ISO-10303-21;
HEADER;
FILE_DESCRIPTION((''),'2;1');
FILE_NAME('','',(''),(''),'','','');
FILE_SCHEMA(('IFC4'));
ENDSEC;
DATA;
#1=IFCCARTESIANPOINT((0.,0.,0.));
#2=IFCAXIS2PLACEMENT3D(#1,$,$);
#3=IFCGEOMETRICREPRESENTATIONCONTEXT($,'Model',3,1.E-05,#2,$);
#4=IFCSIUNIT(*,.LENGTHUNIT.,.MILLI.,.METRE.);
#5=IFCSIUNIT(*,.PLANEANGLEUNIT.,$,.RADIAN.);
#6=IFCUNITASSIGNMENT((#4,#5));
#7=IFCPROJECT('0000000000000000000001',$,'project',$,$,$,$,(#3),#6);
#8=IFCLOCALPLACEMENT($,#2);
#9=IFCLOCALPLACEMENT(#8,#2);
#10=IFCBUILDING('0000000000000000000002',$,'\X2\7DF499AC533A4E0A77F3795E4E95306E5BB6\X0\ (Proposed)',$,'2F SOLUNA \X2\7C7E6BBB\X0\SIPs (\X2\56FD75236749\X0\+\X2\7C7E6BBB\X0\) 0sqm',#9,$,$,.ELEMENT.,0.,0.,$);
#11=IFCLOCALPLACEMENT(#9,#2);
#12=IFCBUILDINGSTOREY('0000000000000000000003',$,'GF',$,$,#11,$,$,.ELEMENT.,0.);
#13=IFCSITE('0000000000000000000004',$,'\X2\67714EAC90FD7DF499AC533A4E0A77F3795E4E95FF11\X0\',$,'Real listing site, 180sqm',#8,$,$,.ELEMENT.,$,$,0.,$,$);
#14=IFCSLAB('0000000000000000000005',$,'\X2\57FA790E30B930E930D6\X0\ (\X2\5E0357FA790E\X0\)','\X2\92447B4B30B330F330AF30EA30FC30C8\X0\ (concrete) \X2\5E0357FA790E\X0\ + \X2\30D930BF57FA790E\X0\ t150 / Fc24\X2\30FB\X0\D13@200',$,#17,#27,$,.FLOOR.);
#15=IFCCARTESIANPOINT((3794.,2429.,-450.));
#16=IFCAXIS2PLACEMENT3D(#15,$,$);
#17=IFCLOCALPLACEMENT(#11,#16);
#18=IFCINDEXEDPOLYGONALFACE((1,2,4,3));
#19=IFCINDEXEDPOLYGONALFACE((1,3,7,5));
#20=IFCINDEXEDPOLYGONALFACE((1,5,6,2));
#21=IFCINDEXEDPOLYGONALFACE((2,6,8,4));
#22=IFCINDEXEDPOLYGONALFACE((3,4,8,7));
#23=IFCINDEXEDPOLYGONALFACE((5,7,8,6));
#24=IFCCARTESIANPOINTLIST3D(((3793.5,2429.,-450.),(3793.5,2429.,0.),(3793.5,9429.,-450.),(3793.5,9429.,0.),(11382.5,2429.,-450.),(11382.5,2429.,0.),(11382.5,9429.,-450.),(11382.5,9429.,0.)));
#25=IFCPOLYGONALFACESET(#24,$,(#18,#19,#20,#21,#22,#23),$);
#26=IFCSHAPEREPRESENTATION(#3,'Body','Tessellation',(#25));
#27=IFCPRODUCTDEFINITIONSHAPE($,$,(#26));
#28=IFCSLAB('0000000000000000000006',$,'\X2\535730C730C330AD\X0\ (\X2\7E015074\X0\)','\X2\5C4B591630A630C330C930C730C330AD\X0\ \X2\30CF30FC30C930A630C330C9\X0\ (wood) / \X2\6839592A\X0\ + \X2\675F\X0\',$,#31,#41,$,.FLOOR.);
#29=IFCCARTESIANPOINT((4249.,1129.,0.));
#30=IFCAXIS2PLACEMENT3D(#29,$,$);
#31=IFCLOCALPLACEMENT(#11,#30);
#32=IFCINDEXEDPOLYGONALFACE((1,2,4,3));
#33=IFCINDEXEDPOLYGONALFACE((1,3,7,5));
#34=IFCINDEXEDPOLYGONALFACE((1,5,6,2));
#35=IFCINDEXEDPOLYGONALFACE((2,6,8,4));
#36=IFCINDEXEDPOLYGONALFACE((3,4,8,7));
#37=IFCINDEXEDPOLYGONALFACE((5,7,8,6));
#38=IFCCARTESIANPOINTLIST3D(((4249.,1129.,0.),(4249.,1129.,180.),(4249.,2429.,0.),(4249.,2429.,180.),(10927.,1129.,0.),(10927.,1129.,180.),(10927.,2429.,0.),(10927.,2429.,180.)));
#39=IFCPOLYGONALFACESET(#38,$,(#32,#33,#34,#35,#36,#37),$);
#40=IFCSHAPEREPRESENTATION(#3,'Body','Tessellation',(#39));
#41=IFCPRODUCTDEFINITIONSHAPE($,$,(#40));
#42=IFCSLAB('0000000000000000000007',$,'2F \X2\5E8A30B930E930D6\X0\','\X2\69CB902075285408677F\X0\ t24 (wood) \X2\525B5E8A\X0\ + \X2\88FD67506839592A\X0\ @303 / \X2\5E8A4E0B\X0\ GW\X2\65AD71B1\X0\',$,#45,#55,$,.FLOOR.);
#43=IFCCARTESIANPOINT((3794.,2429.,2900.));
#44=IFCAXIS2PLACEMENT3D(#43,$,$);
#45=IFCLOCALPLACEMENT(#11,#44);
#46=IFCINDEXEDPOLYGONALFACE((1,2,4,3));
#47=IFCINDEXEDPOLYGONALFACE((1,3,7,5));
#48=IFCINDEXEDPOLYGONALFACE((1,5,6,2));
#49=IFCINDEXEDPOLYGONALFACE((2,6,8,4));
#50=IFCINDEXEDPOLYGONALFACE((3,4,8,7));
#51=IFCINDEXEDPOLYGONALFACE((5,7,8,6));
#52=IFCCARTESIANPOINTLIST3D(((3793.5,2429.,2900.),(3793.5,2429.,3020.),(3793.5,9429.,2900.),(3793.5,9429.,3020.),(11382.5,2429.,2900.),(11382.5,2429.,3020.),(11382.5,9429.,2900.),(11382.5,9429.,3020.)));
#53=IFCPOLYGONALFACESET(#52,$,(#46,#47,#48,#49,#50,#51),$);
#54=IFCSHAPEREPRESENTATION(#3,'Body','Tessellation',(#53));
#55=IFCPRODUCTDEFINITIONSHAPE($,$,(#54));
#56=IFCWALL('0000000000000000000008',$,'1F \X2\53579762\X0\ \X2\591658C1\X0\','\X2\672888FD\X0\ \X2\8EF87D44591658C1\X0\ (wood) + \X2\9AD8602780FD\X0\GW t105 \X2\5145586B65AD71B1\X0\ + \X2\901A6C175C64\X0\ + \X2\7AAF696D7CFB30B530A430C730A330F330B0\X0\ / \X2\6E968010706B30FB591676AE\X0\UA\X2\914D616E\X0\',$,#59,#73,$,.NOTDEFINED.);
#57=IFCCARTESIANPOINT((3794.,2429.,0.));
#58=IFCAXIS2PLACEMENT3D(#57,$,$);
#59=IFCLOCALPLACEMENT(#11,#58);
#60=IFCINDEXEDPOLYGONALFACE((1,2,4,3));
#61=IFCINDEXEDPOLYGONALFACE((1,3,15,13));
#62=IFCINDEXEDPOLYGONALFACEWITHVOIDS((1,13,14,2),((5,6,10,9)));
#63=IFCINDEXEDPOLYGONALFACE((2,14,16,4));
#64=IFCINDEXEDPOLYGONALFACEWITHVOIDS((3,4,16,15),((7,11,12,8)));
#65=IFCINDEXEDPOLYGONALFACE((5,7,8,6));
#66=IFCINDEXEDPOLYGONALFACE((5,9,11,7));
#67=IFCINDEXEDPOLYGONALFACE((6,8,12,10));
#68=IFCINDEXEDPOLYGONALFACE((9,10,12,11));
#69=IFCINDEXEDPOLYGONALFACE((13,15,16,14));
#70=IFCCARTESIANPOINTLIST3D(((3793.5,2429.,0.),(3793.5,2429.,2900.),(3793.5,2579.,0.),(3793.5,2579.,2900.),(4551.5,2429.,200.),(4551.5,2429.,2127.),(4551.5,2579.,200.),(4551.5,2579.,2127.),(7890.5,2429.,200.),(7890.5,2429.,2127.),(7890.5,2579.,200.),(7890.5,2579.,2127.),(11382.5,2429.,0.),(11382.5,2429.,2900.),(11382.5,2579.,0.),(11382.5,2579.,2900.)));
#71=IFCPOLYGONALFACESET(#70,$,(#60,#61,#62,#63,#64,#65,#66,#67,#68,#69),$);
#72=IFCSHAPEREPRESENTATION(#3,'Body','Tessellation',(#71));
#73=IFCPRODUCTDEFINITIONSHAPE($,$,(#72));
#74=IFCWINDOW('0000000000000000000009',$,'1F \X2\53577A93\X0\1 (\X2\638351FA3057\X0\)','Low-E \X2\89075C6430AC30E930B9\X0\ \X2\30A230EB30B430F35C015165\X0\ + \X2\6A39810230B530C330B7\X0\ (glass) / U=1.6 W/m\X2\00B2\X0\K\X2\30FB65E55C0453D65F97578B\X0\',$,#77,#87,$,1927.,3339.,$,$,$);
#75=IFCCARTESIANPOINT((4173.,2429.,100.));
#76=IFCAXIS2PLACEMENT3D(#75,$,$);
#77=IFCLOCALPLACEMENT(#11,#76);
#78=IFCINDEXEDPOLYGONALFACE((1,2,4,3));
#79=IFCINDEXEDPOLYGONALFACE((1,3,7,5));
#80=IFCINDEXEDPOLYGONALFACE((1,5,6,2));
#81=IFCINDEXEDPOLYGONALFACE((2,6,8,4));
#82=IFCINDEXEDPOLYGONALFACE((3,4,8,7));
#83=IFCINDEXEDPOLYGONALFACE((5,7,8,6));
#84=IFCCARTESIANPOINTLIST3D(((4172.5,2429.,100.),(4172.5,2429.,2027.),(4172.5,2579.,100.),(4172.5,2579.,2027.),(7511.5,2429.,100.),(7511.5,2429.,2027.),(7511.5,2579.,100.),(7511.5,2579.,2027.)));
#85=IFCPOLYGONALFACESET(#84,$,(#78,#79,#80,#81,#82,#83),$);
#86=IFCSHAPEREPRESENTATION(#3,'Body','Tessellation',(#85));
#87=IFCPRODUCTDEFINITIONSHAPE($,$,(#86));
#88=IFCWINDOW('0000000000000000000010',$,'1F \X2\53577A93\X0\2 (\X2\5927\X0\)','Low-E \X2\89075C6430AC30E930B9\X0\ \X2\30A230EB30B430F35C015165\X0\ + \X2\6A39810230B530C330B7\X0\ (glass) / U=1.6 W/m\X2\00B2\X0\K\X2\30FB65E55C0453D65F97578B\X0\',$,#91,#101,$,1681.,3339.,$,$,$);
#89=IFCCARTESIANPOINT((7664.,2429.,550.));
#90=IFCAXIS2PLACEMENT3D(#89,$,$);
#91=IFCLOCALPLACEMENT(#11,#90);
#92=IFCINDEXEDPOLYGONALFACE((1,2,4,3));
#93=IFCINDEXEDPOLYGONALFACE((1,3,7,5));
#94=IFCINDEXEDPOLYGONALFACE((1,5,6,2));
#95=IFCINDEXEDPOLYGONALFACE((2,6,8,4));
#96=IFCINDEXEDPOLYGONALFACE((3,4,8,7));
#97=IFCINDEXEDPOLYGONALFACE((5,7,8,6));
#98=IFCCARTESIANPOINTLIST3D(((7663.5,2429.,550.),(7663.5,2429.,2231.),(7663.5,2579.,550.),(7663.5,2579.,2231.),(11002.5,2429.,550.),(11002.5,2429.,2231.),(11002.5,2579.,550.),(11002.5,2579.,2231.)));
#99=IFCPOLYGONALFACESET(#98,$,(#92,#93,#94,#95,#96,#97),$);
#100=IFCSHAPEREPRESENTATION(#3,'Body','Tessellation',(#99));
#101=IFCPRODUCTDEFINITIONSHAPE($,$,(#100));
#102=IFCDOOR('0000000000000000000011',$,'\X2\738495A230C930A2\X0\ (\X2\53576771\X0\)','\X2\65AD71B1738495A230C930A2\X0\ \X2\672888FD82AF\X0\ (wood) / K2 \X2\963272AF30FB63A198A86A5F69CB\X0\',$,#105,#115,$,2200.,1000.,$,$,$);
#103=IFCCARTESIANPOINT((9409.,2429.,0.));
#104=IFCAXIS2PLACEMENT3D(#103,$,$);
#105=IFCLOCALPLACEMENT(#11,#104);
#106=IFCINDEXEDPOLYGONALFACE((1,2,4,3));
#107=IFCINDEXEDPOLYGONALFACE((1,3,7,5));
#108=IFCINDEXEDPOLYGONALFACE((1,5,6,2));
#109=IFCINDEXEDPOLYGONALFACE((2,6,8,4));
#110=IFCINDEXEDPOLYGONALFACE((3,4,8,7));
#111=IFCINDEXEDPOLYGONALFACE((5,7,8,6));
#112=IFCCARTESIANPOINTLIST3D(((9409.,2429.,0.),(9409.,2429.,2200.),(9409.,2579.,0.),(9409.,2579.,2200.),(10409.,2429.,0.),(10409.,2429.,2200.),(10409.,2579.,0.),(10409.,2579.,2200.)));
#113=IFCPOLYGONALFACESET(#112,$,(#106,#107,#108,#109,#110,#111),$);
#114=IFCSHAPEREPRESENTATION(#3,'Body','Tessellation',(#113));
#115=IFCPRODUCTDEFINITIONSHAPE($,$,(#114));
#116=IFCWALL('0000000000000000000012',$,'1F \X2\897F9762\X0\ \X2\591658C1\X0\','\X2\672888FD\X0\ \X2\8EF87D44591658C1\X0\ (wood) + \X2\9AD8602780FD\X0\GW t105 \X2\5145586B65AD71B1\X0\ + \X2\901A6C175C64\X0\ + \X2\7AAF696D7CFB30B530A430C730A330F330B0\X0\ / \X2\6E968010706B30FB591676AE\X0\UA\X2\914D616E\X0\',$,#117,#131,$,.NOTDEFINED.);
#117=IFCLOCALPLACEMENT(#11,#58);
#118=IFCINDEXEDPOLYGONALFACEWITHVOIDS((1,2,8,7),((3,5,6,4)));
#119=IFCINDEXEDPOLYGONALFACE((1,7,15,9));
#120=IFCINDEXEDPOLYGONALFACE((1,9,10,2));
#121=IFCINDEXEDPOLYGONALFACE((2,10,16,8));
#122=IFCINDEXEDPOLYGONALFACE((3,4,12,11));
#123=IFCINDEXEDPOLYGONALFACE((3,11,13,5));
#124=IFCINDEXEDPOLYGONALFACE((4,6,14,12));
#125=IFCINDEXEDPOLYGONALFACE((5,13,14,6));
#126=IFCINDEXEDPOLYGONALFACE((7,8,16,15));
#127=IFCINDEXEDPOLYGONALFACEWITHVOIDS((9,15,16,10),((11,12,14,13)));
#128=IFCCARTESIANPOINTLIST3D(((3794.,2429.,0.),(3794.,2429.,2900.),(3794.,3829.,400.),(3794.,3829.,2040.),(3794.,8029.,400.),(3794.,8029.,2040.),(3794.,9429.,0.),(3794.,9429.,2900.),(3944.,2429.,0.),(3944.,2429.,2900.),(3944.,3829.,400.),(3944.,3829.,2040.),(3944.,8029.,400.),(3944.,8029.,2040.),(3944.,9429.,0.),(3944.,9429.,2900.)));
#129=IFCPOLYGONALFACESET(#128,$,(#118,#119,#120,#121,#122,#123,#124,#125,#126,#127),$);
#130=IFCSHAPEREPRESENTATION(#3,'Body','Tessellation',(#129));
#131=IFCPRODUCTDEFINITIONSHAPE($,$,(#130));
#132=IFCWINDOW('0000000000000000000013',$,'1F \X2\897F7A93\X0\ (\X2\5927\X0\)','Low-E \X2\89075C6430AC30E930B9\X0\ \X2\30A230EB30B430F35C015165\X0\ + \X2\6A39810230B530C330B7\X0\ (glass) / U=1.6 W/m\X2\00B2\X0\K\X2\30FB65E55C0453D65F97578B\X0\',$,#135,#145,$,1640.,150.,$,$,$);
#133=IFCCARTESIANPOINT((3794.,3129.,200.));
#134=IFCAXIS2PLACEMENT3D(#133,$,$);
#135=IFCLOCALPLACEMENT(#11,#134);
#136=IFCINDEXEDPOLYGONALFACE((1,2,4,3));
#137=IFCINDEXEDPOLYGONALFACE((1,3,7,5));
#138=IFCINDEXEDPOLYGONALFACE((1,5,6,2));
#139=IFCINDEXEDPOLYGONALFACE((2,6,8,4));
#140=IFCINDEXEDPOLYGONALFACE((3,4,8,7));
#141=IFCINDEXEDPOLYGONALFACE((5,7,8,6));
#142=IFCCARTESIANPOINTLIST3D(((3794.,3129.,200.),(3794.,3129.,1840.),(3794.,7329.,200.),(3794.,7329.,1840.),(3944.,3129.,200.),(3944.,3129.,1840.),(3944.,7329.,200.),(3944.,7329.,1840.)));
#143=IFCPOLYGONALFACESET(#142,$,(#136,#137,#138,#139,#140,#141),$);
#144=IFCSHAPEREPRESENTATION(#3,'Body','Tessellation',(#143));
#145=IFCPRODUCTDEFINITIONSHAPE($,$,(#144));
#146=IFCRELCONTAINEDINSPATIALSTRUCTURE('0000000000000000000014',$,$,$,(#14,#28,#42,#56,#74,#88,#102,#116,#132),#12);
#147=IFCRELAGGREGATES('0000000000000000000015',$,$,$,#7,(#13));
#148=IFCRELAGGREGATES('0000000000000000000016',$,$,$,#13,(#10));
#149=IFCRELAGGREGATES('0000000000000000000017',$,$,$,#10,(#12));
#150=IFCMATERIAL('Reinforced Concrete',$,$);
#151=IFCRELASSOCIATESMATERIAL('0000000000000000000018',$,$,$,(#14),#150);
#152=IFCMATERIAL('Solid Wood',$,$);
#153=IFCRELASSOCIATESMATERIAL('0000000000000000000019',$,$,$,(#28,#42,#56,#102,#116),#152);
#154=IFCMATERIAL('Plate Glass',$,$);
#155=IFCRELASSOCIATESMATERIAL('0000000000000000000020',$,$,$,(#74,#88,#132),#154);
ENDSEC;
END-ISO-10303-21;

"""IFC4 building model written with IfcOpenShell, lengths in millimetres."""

from ifc_helpers import new_model, si_unit, frame, frame_2d, origin, place, context, project, spatial, rectangle, extrude, material, element, fill, save


model = new_model("IFC4")

# Units and contexts
model_context = context("Model", 3, precision=1e-05, world=origin())
ifc_project = project(units=[si_unit("LENGTHUNIT", "METRE", prefix="MILLI"), si_unit("PLANEANGLEUNIT", "RADIAN")], contexts=[model_context])

# Site, building, storey
site_placement = place(None, origin())
site = spatial("IfcSite", under=ifc_project, at=site_placement, Name="東京都練馬区上石神井１", ObjectType="Real listing site, 180sqm", CompositionType="ELEMENT", RefElevation=0.0)
building_placement = place(site_placement, origin())
building = spatial("IfcBuilding", under=site, at=building_placement, Name="練馬区上石神井の家 (Proposed)", ObjectType="2F SOLUNA 籾殻SIPs (国産杉+籾殻) 0sqm", CompositionType="ELEMENT", ElevationOfRefHeight=0.0, ElevationOfTerrain=0.0)
storey_placement = place(building_placement, origin())
storey = spatial("IfcBuildingStorey", under=building, at=storey_placement, Name="GF", CompositionType="ELEMENT", Elevation=0.0)

# Slabs
ifc_material_1 = material(Name="Reinforced Concrete")
slab_1_placement = place(storey_placement, frame((3794.0, 2429.0, -450.0)))
element("IfcSlab", 1, at=slab_1_placement, inside=storey, material=ifc_material_1, Name="基礎スラブ (布基礎)", Description="鉄筋コンクリート (concrete) 布基礎 + ベタ基礎 t150 / Fc24・D13@200", PredefinedType="FLOOR", context=model_context, shape_type="SweptSolid", body=[
    extrude(rectangle(XDim=7589.0, YDim=7000.0, at=frame_2d((3794.0, 3500.0))), frame((3794.0, 2429.0, -450.0)), (0.0, 0.0, 1.0), 450.0),
])
ifc_material_2 = material(Name="Solid Wood")
slab_2_placement = place(storey_placement, frame((4249.0, 1129.0, 0.0)))
element("IfcSlab", 2, at=slab_2_placement, inside=storey, material=ifc_material_2, Name="南デッキ (縁側)", Description="屋外ウッドデッキ ハードウッド (wood) / 根太 + 束", PredefinedType="FLOOR", context=model_context, shape_type="SweptSolid", body=[
    extrude(rectangle(XDim=6678.0, YDim=1300.0, at=frame_2d((3339.0, 650.0))), frame((4249.0, 1129.0, 0.0)), (0.0, 0.0, 1.0), 180.0),
])
slab_3_placement = place(storey_placement, frame((3794.0, 2429.0, 2900.0)))
element("IfcSlab", 3, at=slab_3_placement, inside=storey, material=ifc_material_2, Name="2F 床スラブ", Description="構造用合板 t24 (wood) 剛床 + 製材根太 @303 / 床下 GW断熱", PredefinedType="FLOOR", context=model_context, shape_type="SweptSolid", body=[
    extrude(rectangle(XDim=7589.0, YDim=7000.0, at=frame_2d((3794.0, 3500.0))), frame((3794.0, 2429.0, 2900.0)), (0.0, 0.0, 1.0), 120.0),
])

# Wall, openings, windows, door
wall_1_placement = place(storey_placement, frame((3794.0, 2429.0, 0.0)))
wall_1 = element("IfcWall", 4, at=wall_1_placement, inside=storey, material=ifc_material_2, Name="1F 南面 外壁", Description="木製 軸組外壁 (wood) + 高性能GW t105 充填断熱 + 通気層 + 窯業系サイディング / 準耐火・外皮UA配慮", PredefinedType="NOTDEFINED", context=model_context, shape_type="SweptSolid", body=[
    extrude(rectangle(XDim=7589.0, YDim=150.0, at=frame_2d((3794.0, 75.0))), frame((3794.0, 2429.0, 0.0)), (0.0, 0.0, 1.0), 2900.0),
])
opening_1_placement = place(storey_placement, frame((4173.0, 2429.0, 100.0)))
opening_1 = element("IfcOpeningElement", 5, at=opening_1_placement, cuts=wall_1, PredefinedType="NOTDEFINED", context=model_context, shape_type="SweptSolid", body=[
    extrude(rectangle(XDim=3339.0, YDim=150.0, at=frame_2d((1669.0, 75.0))), frame((4173.0, 2429.0, 100.0)), (0.0, 0.0, 1.0), 1927.0),
])
opening_2_placement = place(storey_placement, frame((7664.0, 2429.0, 550.0)))
opening_2 = element("IfcOpeningElement", 6, at=opening_2_placement, cuts=wall_1, PredefinedType="NOTDEFINED", context=model_context, shape_type="SweptSolid", body=[
    extrude(rectangle(XDim=3339.0, YDim=150.0, at=frame_2d((1669.0, 75.0))), frame((7664.0, 2429.0, 550.0)), (0.0, 0.0, 1.0), 1681.0),
])
opening_3_placement = place(storey_placement, frame((9409.0, 2429.0, 0.0)))
opening_3 = element("IfcOpeningElement", 7, at=opening_3_placement, cuts=wall_1, PredefinedType="NOTDEFINED", context=model_context, shape_type="SweptSolid", body=[
    extrude(rectangle(XDim=1000.0, YDim=150.0, at=frame_2d((500.0, 75.0))), frame((9409.0, 2429.0, 0.0)), (0.0, 0.0, 1.0), 2200.0),
])
ifc_material_3 = material(Name="Plate Glass")
window_1_placement = place(storey_placement, frame((4173.0, 2429.0, 100.0)))
window_1 = element("IfcWindow", 8, at=window_1_placement, inside=storey, material=ifc_material_3, Name="1F 南窓1 (掃出し)", Description="Low-E 複層ガラス アルゴン封入 + 樹脂サッシ (glass) / U=1.6 W/m²K・日射取得型", OverallHeight=1927.0, OverallWidth=3339.0, context=model_context, shape_type="SweptSolid", body=[
    extrude(rectangle(XDim=3339.0, YDim=150.0, at=frame_2d((1669.0, 75.0))), frame((4173.0, 2429.0, 100.0)), (0.0, 0.0, 1.0), 1927.0),
])
fill(opening_1, window_1)
window_2_placement = place(storey_placement, frame((7664.0, 2429.0, 550.0)))
window_2 = element("IfcWindow", 9, at=window_2_placement, inside=storey, material=ifc_material_3, Name="1F 南窓2 (大)", Description="Low-E 複層ガラス アルゴン封入 + 樹脂サッシ (glass) / U=1.6 W/m²K・日射取得型", OverallHeight=1681.0, OverallWidth=3339.0, context=model_context, shape_type="SweptSolid", body=[
    extrude(rectangle(XDim=3339.0, YDim=150.0, at=frame_2d((1669.0, 75.0))), frame((7664.0, 2429.0, 550.0)), (0.0, 0.0, 1.0), 1681.0),
])
fill(opening_2, window_2)
door_placement = place(storey_placement, frame((9409.0, 2429.0, 0.0)))
door = element("IfcDoor", 10, at=door_placement, inside=storey, material=ifc_material_2, Name="玄関ドア (南東)", Description="断熱玄関ドア 木製芯 (wood) / K2 防犯・採風機構", OverallHeight=2200.0, OverallWidth=1000.0, context=model_context, shape_type="SweptSolid", body=[
    extrude(rectangle(XDim=1000.0, YDim=150.0, at=frame_2d((500.0, 75.0))), frame((9409.0, 2429.0, 0.0)), (0.0, 0.0, 1.0), 2200.0),
])
fill(opening_3, door)

# Wall, opening, window
wall_2_placement = place(storey_placement, frame((3794.0, 2429.0, 0.0)))
wall_2 = element("IfcWall", 11, at=wall_2_placement, inside=storey, material=ifc_material_2, Name="1F 西面 外壁", Description="木製 軸組外壁 (wood) + 高性能GW t105 充填断熱 + 通気層 + 窯業系サイディング / 準耐火・外皮UA配慮", PredefinedType="NOTDEFINED", context=model_context, shape_type="SweptSolid", body=[
    extrude(rectangle(XDim=150.0, YDim=7000.0, at=frame_2d((75.0, 3500.0))), frame((3794.0, 2429.0, 0.0)), (0.0, 0.0, 1.0), 2900.0),
])
opening_4_placement = place(storey_placement, frame((3794.0, 3129.0, 200.0)))
opening_4 = element("IfcOpeningElement", 12, at=opening_4_placement, cuts=wall_2, PredefinedType="NOTDEFINED", context=model_context, shape_type="SweptSolid", body=[
    extrude(rectangle(XDim=150.0, YDim=4200.0, at=frame_2d((75.0, 2100.0))), frame((3794.0, 3129.0, 200.0)), (0.0, 0.0, 1.0), 1640.0),
])
window_3_placement = place(storey_placement, frame((3794.0, 3129.0, 200.0)))
window_3 = element("IfcWindow", 13, at=window_3_placement, inside=storey, material=ifc_material_3, Name="1F 西窓 (大)", Description="Low-E 複層ガラス アルゴン封入 + 樹脂サッシ (glass) / U=1.6 W/m²K・日射取得型", OverallHeight=1640.0, OverallWidth=150.0, context=model_context, shape_type="SweptSolid", body=[
    extrude(rectangle(XDim=150.0, YDim=4200.0, at=frame_2d((75.0, 2100.0))), frame((3794.0, 3129.0, 200.0)), (0.0, 0.0, 1.0), 1640.0),
])
fill(opening_4, window_3)

save(model, "model.ifc")
